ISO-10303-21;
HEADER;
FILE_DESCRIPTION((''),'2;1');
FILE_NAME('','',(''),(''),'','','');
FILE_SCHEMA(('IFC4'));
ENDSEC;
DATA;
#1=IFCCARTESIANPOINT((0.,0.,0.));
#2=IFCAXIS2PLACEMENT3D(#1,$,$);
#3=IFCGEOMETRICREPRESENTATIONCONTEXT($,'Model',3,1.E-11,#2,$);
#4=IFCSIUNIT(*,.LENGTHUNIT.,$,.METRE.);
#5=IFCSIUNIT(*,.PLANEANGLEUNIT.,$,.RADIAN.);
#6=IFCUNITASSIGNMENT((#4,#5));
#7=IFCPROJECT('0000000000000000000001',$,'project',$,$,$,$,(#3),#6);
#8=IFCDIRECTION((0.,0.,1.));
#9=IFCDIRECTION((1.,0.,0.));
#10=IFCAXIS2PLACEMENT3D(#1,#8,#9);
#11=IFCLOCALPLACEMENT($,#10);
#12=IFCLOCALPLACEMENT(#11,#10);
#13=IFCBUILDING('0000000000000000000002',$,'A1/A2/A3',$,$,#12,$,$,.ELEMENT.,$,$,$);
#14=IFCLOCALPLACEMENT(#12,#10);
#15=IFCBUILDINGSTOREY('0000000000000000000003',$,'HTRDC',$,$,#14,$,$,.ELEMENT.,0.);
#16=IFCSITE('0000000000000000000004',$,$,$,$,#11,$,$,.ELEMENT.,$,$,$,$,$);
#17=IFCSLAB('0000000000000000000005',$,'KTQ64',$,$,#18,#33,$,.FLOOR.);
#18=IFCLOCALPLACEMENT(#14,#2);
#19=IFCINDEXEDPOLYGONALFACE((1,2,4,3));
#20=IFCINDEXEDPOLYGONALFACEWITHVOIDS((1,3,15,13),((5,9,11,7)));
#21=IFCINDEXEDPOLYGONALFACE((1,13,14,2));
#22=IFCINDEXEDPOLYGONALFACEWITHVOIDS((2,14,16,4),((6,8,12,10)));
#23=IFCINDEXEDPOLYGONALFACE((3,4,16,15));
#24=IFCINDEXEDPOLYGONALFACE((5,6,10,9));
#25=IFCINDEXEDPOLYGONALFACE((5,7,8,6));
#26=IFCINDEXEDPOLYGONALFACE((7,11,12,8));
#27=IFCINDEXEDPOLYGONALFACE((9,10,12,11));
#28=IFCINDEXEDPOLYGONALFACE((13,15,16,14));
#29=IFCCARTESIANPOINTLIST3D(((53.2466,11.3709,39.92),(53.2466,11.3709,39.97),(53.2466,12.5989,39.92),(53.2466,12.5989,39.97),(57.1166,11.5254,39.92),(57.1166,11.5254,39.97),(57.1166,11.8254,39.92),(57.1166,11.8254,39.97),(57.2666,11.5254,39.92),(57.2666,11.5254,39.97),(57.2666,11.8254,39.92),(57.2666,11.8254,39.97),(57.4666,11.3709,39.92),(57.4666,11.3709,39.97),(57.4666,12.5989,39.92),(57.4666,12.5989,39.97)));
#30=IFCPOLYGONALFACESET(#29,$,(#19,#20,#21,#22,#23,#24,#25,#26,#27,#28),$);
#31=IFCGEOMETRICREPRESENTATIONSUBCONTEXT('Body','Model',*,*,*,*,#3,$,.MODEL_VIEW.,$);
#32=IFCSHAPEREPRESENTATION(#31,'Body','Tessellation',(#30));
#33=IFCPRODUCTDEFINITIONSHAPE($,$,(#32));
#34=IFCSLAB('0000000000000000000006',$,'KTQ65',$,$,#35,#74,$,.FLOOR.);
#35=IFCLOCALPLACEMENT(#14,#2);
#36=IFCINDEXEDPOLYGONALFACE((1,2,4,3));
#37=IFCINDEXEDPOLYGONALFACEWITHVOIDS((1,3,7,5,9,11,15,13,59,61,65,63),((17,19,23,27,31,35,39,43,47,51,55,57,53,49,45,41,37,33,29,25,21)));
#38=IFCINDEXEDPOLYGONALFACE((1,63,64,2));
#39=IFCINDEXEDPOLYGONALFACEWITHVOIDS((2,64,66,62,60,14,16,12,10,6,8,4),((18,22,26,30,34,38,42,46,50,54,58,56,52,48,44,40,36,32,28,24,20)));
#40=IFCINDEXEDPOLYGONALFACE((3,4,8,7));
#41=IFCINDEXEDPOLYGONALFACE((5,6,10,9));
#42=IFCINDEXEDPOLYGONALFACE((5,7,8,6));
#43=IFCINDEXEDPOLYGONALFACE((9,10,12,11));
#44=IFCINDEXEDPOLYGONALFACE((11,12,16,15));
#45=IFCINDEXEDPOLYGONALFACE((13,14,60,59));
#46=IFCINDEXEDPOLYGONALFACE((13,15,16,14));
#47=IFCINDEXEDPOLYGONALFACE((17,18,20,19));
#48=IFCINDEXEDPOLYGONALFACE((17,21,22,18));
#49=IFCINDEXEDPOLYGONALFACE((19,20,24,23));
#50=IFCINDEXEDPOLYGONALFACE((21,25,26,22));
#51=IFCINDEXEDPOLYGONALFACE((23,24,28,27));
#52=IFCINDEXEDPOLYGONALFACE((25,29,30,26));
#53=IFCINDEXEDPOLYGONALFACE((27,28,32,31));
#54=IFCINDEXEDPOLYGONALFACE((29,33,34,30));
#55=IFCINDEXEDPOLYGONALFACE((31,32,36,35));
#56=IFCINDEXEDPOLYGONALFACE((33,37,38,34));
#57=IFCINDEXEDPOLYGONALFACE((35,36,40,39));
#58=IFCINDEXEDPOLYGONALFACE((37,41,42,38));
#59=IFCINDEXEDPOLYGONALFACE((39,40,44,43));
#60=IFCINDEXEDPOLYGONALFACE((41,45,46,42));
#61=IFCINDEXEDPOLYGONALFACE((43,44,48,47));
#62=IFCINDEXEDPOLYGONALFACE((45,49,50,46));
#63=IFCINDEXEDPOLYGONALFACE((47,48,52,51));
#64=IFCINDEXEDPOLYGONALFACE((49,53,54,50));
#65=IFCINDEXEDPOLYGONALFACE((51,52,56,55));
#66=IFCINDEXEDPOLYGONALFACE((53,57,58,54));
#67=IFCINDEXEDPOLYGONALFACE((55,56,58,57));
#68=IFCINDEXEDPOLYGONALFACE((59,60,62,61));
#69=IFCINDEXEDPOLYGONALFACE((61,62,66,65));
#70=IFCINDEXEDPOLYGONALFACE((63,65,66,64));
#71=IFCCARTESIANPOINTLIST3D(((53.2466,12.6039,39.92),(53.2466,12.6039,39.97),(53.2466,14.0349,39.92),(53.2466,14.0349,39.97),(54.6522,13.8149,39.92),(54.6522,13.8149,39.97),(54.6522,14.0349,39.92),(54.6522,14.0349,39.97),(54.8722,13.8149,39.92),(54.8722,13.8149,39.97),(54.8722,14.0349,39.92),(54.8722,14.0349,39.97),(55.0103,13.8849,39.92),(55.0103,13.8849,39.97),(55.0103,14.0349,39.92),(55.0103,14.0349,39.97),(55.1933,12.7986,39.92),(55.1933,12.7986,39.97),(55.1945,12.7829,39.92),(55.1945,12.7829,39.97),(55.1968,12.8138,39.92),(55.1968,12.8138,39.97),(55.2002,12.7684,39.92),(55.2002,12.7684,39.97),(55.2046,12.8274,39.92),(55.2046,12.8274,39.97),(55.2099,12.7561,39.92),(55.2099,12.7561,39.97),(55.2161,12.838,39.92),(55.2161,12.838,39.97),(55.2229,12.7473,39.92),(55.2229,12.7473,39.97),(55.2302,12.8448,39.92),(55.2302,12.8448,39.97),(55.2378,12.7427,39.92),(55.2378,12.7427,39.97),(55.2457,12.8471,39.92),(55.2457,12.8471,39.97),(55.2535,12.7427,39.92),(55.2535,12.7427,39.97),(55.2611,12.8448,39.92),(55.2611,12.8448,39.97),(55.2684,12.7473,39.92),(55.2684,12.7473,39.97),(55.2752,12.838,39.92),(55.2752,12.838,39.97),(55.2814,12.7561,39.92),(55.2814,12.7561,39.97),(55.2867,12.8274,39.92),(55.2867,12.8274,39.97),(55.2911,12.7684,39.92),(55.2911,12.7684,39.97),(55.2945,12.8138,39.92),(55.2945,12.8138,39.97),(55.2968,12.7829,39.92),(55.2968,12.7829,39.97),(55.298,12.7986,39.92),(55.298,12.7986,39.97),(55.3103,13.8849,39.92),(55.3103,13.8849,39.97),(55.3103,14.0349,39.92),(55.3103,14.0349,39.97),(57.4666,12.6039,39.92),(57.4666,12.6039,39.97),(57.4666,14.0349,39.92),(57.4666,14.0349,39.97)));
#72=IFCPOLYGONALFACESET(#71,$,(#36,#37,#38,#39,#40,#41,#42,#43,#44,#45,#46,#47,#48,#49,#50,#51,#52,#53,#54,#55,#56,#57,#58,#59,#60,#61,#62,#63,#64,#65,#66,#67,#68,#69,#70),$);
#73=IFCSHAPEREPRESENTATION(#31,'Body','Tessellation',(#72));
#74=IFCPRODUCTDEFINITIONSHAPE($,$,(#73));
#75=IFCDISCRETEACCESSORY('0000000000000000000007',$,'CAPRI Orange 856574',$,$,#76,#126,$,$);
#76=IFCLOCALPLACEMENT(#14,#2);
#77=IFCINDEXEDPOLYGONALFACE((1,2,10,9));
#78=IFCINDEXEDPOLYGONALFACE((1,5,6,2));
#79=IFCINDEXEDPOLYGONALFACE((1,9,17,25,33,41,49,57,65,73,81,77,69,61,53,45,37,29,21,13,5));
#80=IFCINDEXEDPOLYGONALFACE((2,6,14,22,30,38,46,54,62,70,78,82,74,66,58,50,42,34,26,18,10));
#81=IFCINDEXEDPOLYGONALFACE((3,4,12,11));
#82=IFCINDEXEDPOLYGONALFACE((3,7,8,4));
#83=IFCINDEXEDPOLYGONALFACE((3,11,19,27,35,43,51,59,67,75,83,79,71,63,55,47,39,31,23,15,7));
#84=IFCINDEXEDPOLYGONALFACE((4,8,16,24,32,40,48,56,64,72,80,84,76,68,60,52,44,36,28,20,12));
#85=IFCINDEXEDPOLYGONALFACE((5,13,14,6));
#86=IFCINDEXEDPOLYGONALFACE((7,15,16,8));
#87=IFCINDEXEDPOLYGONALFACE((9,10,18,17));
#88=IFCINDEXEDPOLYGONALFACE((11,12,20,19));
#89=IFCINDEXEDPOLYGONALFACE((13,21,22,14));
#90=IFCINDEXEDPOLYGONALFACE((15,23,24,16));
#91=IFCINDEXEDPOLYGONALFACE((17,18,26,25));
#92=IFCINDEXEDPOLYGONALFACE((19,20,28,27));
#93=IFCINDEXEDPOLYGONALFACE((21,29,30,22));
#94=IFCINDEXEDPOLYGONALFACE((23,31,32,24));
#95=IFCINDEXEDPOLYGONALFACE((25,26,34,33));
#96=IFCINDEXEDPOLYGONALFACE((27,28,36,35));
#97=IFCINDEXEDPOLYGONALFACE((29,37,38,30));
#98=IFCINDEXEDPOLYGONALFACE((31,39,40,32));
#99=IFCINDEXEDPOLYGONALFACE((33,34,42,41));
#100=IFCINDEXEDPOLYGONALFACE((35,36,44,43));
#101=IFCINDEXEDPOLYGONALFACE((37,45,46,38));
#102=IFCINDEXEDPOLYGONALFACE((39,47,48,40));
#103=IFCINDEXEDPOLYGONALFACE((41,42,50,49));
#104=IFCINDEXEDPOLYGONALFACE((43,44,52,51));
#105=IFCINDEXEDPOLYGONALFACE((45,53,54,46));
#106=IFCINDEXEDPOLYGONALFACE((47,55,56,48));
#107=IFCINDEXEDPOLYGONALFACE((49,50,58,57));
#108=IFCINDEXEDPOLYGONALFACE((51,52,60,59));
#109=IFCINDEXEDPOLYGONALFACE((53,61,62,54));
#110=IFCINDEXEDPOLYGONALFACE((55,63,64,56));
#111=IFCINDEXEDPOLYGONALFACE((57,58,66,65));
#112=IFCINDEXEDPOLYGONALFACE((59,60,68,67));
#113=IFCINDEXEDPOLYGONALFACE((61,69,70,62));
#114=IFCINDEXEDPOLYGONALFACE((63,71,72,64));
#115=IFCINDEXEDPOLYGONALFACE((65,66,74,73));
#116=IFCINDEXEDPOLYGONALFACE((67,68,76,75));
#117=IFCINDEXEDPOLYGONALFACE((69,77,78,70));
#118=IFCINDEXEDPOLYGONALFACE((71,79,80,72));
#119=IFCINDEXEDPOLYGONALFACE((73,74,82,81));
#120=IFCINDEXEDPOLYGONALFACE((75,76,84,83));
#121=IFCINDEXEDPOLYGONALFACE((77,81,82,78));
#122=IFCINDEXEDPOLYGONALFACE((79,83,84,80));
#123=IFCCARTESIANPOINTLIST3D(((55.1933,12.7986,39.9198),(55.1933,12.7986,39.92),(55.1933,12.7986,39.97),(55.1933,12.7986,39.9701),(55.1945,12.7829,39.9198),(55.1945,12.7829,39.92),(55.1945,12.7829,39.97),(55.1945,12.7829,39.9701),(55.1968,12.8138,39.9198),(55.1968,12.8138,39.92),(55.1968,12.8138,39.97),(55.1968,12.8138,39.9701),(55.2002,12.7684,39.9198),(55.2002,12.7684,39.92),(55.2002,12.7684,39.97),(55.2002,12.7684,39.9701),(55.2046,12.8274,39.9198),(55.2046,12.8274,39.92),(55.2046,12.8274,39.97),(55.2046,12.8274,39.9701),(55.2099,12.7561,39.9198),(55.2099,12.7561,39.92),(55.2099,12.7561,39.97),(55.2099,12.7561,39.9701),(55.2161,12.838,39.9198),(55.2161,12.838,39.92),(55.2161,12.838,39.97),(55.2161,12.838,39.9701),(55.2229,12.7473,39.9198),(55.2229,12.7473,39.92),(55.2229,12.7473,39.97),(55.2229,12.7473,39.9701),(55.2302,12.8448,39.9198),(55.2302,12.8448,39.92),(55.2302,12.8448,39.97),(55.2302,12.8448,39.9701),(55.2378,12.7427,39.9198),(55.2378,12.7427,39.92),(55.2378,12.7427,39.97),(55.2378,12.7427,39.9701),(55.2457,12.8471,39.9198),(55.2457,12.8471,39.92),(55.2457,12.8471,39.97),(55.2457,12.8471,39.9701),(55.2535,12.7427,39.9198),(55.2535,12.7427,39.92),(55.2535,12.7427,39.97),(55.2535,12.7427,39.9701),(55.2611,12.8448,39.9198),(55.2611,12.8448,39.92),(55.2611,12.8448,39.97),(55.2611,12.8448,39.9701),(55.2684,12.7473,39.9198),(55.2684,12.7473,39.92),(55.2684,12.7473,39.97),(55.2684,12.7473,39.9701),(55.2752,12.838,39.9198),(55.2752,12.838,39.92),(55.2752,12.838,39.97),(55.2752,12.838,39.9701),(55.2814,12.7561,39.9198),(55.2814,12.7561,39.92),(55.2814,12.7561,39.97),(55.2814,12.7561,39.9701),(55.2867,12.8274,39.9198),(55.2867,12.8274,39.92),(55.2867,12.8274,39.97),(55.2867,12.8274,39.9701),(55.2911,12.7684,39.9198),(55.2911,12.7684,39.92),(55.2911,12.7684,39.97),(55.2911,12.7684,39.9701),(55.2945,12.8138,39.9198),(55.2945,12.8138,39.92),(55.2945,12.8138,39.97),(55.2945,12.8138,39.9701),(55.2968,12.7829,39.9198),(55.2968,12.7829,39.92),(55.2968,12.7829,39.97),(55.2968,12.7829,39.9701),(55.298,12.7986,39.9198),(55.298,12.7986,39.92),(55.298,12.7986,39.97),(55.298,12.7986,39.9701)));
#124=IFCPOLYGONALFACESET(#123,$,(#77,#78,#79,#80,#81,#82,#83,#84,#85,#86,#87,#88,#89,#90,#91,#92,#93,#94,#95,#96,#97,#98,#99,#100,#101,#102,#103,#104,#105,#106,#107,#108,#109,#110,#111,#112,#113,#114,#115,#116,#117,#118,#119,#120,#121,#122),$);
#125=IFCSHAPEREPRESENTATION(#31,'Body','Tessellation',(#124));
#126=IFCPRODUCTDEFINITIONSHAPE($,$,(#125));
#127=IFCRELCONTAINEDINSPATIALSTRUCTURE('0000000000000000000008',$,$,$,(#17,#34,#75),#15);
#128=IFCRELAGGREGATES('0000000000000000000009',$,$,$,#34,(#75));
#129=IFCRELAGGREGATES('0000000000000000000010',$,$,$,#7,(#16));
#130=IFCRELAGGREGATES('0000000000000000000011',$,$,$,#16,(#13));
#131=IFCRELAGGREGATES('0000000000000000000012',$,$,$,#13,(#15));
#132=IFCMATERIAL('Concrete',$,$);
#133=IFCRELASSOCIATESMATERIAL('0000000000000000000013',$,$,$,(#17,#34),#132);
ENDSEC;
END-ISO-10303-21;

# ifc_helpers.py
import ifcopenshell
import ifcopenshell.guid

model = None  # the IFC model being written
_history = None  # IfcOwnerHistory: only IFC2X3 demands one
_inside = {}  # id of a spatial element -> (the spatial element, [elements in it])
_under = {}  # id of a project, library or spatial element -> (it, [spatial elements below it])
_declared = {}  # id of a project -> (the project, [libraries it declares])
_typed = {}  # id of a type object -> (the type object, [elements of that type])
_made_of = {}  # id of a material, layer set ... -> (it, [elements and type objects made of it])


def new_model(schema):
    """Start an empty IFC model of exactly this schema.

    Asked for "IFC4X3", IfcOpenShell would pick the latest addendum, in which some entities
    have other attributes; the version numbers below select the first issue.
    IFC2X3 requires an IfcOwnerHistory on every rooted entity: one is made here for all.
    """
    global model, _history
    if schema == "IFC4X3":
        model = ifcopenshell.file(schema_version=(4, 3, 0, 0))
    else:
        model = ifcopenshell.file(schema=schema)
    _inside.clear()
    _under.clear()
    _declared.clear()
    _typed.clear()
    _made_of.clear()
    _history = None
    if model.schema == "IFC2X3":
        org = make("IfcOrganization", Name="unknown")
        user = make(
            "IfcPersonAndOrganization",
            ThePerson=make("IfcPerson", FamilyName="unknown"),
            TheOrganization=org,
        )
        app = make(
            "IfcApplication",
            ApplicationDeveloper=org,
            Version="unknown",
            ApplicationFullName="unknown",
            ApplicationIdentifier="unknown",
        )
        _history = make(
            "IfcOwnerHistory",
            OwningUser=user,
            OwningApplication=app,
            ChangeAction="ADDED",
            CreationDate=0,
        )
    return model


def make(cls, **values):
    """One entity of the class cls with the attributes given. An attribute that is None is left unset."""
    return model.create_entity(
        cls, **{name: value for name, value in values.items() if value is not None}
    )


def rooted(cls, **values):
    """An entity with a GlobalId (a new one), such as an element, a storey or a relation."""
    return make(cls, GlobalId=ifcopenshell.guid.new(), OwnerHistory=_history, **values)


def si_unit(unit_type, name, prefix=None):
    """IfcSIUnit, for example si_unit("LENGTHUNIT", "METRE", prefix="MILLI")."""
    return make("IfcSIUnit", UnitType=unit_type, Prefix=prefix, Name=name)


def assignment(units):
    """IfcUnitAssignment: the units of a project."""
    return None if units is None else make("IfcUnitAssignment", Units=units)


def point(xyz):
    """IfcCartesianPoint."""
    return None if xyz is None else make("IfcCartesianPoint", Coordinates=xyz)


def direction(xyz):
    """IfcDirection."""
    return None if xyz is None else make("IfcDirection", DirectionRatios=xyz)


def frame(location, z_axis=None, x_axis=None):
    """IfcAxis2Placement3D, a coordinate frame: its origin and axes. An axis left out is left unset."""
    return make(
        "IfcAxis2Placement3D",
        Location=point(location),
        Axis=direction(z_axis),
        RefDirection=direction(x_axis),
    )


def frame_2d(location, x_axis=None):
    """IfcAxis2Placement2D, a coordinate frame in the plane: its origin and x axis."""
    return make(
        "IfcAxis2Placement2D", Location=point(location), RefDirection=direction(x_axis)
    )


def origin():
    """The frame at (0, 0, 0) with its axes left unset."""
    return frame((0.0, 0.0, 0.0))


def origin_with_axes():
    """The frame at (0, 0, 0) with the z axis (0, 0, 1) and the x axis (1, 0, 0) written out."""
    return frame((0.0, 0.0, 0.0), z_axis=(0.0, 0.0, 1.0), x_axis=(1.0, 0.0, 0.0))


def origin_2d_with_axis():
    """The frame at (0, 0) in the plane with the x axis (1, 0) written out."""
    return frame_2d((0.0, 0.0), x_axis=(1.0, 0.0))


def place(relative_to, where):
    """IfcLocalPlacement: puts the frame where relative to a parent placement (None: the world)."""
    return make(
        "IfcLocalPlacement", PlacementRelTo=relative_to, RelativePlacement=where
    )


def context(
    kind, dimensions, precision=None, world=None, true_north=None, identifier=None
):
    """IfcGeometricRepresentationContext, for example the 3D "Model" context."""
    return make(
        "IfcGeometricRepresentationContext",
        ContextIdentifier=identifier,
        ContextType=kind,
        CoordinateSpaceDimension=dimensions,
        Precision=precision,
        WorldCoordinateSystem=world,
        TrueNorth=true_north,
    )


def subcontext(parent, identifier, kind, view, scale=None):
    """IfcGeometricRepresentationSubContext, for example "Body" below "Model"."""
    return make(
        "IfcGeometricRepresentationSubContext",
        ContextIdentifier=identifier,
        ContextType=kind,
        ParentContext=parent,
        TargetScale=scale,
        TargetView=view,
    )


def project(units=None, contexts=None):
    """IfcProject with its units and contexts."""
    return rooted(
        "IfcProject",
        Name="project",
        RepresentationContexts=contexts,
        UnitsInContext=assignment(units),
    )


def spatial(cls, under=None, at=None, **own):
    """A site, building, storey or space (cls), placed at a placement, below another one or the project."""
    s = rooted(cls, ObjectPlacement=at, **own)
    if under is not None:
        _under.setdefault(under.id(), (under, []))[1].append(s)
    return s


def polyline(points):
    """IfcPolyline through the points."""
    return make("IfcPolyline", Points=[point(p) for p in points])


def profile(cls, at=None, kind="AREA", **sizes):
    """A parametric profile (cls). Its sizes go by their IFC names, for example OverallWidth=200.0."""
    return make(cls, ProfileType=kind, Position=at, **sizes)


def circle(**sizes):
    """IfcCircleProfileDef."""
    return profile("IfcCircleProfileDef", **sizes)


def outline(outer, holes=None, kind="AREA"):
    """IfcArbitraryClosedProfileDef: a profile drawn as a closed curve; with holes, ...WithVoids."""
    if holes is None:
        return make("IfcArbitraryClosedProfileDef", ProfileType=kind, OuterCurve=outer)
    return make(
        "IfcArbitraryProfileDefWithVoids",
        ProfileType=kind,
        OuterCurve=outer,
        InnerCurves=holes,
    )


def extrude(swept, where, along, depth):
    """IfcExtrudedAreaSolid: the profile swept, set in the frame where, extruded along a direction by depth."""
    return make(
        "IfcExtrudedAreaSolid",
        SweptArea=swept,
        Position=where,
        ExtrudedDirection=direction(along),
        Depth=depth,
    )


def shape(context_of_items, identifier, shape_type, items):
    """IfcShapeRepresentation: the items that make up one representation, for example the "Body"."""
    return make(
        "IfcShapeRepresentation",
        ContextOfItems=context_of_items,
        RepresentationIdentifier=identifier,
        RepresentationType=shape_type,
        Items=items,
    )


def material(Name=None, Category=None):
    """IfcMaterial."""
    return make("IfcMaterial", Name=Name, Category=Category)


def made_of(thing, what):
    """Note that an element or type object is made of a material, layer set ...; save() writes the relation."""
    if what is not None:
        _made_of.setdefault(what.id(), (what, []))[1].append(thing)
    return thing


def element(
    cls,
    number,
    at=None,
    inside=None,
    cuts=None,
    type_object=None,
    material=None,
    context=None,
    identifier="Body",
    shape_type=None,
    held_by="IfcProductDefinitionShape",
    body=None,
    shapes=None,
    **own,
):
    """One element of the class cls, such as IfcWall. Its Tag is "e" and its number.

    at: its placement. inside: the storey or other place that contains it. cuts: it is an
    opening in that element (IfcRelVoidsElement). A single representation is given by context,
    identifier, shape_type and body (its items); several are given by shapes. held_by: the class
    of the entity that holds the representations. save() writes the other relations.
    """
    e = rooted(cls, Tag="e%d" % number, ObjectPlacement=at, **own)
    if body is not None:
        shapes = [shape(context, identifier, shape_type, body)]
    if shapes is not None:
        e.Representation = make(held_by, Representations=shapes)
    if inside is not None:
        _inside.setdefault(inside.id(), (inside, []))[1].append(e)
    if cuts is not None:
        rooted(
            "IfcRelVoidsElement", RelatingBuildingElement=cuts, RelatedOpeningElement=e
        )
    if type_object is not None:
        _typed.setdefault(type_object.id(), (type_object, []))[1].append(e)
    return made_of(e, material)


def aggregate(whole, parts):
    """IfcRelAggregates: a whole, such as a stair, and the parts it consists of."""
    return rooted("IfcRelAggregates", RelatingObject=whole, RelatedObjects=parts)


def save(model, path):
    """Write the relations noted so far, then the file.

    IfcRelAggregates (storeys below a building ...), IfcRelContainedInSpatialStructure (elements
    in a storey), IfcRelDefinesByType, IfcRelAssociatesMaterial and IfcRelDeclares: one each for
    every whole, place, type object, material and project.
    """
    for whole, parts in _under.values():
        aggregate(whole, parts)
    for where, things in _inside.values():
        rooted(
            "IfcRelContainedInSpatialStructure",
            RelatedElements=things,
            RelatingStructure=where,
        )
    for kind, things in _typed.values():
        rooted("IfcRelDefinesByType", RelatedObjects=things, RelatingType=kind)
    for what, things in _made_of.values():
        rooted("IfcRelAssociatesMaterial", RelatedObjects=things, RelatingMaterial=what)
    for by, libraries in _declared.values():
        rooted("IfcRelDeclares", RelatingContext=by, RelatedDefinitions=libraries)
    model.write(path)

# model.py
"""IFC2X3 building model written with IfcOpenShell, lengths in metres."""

from ifc_helpers import new_model, si_unit, frame, frame_2d, origin, origin_with_axes, origin_2d_with_axis, place, context, subcontext, project, spatial, polyline, circle, outline, extrude, material, element, aggregate, save


model = new_model("IFC2X3")

# Units and contexts
model_context = context("Model", 3, precision=1e-11, world=origin())
body_context = subcontext(model_context, "Body", "Model", "MODEL_VIEW")
ifc_project = project(units=[si_unit("LENGTHUNIT", "METRE"), si_unit("PLANEANGLEUNIT", "RADIAN")], contexts=[model_context])

# Site, building, storey
site_placement = place(None, origin_with_axes())
site = spatial("IfcSite", under=ifc_project, at=site_placement, CompositionType="ELEMENT")
building_placement = place(site_placement, origin_with_axes())
building = spatial("IfcBuilding", under=site, at=building_placement, Name="A1/A2/A3", CompositionType="ELEMENT")
storey_placement = place(building_placement, origin_with_axes())
storey = spatial("IfcBuildingStorey", under=building, at=storey_placement, Name="HTRDC", CompositionType="ELEMENT", Elevation=0.0)

# Shared definitions
ifc_material = material(Name="Concrete")

# Slab, opening
slab_1_placement = place(storey_placement, frame((53.2466, 11.3709, 39.92), z_axis=(0.0, 0.0, 1.0), x_axis=(1.0, 0.0, 0.0)))
slab_1 = element("IfcSlab", 1, at=slab_1_placement, inside=storey, material=ifc_material, Name="KTQ64", PredefinedType="FLOOR", context=body_context, shape_type="SweptSolid", body=[
    extrude(outline(polyline([(0.0, 0.0), (0.0, -4.22), (1.228, -4.22), (1.228, 0.0), (0.0, 0.0)])), frame((0.0, 0.0, 0.0), z_axis=(0.0, 0.0, 1.0), x_axis=(0.0, 1.0, 0.0)), (0.0, 0.0, 1.0), 0.05),
])
opening_1_placement = place(slab_1_placement, origin_with_axes())
element("IfcOpeningElement", 2, at=opening_1_placement, cuts=slab_1, ObjectType="Opening", context=body_context, shape_type="SweptSolid", body=[
    extrude(outline(polyline([(0.1545, -3.87), (0.1545, -4.02), (0.4545, -4.02), (0.4545, -3.87), (0.1545, -3.87)])), frame((0.0, 0.0, 0.0), z_axis=(0.0, 0.0, 1.0), x_axis=(0.0, 1.0, 0.0)), (0.0, 0.0, 1.0), 0.05),
])

# Slab, openings
slab_2_placement = place(storey_placement, frame((53.2466, 12.6039, 39.92), z_axis=(0.0, 0.0, 1.0), x_axis=(1.0, 0.0, 0.0)))
slab_2 = element("IfcSlab", 3, at=slab_2_placement, inside=storey, material=ifc_material, Name="KTQ65", PredefinedType="FLOOR", context=body_context, shape_type="SweptSolid", body=[
    extrude(outline(polyline([(0.0, 0.0), (0.0, -4.22), (1.431, -4.22), (1.431, 0.0), (0.0, 0.0)])), frame((0.0, 0.0, 0.0), z_axis=(0.0, 0.0, 1.0), x_axis=(0.0, 1.0, 0.0)), (0.0, 0.0, 1.0), 0.05),
])
opening_2_placement = place(slab_2_placement, origin_with_axes())
element("IfcOpeningElement", 4, at=opening_2_placement, cuts=slab_2, ObjectType="Opening", context=body_context, shape_type="SweptSolid", body=[
    extrude(outline(polyline([(1.211, -1.4056), (1.211, -1.6256), (1.431, -1.6256), (1.431, -1.4056), (1.211, -1.4056)])), frame((0.0, 0.0, 0.0), z_axis=(0.0, 0.0, 1.0), x_axis=(0.0, 1.0, 0.0)), (0.0, 0.0, 1.0), 0.05),
])
opening_3_placement = place(slab_2_placement, origin_with_axes())
element("IfcOpeningElement", 5, at=opening_3_placement, cuts=slab_2, ObjectType="Opening", context=body_context, shape_type="SweptSolid", body=[
    extrude(outline(polyline([(1.2811, -1.7637), (1.2811, -2.0637), (1.431, -2.0637), (1.431, -1.7637), (1.2811, -1.7637)])), frame((0.0, 0.0, 0.0), z_axis=(0.0, 0.0, 1.0), x_axis=(0.0, 1.0, 0.0)), (0.0, 0.0, 1.0), 0.05),
])
opening_4_placement = place(slab_2_placement, frame((1.9991, 0.1908, 0.0), z_axis=(0.0, 0.0, 1.0), x_axis=(1.0, 0.0, 0.0)))
element("IfcOpeningElement", 6, at=opening_4_placement, cuts=slab_2, ObjectType="Opening", context=body_context, shape_type="SweptSolid", body=[
    extrude(circle(Radius=0.0525, at=origin_2d_with_axis()), frame((0.0, 0.0, 0.0), z_axis=(0.0, 0.0, 1.0), x_axis=(0.0, 1.0, 0.0)), (0.0, 0.0, 1.0), 0.05),
])

# Discrete accessory
discrete_accessory_1_placement = place(storey_placement, frame((53.2466, 12.6039, 39.9198), z_axis=(0.0, 0.0, 1.0), x_axis=(1.0, 0.0, 0.0)))
discrete_accessory_1 = element("IfcDiscreteAccessory", 7, at=discrete_accessory_1_placement, inside=storey, Name="CAPRI Orange 856574", context=body_context, shape_type="SweptSolid", body=[
    extrude(circle(Radius=0.0525, at=frame_2d((0.1908, -1.9991), x_axis=(1.0, 0.0))), frame((0.0, 0.0, 0.0), z_axis=(0.0, 0.0, 1.0), x_axis=(0.0, 1.0, 0.0)), (0.0, 0.0, 1.0), 0.0503),
])
aggregate(slab_2, [discrete_accessory_1])

save(model, "model.ifc")
